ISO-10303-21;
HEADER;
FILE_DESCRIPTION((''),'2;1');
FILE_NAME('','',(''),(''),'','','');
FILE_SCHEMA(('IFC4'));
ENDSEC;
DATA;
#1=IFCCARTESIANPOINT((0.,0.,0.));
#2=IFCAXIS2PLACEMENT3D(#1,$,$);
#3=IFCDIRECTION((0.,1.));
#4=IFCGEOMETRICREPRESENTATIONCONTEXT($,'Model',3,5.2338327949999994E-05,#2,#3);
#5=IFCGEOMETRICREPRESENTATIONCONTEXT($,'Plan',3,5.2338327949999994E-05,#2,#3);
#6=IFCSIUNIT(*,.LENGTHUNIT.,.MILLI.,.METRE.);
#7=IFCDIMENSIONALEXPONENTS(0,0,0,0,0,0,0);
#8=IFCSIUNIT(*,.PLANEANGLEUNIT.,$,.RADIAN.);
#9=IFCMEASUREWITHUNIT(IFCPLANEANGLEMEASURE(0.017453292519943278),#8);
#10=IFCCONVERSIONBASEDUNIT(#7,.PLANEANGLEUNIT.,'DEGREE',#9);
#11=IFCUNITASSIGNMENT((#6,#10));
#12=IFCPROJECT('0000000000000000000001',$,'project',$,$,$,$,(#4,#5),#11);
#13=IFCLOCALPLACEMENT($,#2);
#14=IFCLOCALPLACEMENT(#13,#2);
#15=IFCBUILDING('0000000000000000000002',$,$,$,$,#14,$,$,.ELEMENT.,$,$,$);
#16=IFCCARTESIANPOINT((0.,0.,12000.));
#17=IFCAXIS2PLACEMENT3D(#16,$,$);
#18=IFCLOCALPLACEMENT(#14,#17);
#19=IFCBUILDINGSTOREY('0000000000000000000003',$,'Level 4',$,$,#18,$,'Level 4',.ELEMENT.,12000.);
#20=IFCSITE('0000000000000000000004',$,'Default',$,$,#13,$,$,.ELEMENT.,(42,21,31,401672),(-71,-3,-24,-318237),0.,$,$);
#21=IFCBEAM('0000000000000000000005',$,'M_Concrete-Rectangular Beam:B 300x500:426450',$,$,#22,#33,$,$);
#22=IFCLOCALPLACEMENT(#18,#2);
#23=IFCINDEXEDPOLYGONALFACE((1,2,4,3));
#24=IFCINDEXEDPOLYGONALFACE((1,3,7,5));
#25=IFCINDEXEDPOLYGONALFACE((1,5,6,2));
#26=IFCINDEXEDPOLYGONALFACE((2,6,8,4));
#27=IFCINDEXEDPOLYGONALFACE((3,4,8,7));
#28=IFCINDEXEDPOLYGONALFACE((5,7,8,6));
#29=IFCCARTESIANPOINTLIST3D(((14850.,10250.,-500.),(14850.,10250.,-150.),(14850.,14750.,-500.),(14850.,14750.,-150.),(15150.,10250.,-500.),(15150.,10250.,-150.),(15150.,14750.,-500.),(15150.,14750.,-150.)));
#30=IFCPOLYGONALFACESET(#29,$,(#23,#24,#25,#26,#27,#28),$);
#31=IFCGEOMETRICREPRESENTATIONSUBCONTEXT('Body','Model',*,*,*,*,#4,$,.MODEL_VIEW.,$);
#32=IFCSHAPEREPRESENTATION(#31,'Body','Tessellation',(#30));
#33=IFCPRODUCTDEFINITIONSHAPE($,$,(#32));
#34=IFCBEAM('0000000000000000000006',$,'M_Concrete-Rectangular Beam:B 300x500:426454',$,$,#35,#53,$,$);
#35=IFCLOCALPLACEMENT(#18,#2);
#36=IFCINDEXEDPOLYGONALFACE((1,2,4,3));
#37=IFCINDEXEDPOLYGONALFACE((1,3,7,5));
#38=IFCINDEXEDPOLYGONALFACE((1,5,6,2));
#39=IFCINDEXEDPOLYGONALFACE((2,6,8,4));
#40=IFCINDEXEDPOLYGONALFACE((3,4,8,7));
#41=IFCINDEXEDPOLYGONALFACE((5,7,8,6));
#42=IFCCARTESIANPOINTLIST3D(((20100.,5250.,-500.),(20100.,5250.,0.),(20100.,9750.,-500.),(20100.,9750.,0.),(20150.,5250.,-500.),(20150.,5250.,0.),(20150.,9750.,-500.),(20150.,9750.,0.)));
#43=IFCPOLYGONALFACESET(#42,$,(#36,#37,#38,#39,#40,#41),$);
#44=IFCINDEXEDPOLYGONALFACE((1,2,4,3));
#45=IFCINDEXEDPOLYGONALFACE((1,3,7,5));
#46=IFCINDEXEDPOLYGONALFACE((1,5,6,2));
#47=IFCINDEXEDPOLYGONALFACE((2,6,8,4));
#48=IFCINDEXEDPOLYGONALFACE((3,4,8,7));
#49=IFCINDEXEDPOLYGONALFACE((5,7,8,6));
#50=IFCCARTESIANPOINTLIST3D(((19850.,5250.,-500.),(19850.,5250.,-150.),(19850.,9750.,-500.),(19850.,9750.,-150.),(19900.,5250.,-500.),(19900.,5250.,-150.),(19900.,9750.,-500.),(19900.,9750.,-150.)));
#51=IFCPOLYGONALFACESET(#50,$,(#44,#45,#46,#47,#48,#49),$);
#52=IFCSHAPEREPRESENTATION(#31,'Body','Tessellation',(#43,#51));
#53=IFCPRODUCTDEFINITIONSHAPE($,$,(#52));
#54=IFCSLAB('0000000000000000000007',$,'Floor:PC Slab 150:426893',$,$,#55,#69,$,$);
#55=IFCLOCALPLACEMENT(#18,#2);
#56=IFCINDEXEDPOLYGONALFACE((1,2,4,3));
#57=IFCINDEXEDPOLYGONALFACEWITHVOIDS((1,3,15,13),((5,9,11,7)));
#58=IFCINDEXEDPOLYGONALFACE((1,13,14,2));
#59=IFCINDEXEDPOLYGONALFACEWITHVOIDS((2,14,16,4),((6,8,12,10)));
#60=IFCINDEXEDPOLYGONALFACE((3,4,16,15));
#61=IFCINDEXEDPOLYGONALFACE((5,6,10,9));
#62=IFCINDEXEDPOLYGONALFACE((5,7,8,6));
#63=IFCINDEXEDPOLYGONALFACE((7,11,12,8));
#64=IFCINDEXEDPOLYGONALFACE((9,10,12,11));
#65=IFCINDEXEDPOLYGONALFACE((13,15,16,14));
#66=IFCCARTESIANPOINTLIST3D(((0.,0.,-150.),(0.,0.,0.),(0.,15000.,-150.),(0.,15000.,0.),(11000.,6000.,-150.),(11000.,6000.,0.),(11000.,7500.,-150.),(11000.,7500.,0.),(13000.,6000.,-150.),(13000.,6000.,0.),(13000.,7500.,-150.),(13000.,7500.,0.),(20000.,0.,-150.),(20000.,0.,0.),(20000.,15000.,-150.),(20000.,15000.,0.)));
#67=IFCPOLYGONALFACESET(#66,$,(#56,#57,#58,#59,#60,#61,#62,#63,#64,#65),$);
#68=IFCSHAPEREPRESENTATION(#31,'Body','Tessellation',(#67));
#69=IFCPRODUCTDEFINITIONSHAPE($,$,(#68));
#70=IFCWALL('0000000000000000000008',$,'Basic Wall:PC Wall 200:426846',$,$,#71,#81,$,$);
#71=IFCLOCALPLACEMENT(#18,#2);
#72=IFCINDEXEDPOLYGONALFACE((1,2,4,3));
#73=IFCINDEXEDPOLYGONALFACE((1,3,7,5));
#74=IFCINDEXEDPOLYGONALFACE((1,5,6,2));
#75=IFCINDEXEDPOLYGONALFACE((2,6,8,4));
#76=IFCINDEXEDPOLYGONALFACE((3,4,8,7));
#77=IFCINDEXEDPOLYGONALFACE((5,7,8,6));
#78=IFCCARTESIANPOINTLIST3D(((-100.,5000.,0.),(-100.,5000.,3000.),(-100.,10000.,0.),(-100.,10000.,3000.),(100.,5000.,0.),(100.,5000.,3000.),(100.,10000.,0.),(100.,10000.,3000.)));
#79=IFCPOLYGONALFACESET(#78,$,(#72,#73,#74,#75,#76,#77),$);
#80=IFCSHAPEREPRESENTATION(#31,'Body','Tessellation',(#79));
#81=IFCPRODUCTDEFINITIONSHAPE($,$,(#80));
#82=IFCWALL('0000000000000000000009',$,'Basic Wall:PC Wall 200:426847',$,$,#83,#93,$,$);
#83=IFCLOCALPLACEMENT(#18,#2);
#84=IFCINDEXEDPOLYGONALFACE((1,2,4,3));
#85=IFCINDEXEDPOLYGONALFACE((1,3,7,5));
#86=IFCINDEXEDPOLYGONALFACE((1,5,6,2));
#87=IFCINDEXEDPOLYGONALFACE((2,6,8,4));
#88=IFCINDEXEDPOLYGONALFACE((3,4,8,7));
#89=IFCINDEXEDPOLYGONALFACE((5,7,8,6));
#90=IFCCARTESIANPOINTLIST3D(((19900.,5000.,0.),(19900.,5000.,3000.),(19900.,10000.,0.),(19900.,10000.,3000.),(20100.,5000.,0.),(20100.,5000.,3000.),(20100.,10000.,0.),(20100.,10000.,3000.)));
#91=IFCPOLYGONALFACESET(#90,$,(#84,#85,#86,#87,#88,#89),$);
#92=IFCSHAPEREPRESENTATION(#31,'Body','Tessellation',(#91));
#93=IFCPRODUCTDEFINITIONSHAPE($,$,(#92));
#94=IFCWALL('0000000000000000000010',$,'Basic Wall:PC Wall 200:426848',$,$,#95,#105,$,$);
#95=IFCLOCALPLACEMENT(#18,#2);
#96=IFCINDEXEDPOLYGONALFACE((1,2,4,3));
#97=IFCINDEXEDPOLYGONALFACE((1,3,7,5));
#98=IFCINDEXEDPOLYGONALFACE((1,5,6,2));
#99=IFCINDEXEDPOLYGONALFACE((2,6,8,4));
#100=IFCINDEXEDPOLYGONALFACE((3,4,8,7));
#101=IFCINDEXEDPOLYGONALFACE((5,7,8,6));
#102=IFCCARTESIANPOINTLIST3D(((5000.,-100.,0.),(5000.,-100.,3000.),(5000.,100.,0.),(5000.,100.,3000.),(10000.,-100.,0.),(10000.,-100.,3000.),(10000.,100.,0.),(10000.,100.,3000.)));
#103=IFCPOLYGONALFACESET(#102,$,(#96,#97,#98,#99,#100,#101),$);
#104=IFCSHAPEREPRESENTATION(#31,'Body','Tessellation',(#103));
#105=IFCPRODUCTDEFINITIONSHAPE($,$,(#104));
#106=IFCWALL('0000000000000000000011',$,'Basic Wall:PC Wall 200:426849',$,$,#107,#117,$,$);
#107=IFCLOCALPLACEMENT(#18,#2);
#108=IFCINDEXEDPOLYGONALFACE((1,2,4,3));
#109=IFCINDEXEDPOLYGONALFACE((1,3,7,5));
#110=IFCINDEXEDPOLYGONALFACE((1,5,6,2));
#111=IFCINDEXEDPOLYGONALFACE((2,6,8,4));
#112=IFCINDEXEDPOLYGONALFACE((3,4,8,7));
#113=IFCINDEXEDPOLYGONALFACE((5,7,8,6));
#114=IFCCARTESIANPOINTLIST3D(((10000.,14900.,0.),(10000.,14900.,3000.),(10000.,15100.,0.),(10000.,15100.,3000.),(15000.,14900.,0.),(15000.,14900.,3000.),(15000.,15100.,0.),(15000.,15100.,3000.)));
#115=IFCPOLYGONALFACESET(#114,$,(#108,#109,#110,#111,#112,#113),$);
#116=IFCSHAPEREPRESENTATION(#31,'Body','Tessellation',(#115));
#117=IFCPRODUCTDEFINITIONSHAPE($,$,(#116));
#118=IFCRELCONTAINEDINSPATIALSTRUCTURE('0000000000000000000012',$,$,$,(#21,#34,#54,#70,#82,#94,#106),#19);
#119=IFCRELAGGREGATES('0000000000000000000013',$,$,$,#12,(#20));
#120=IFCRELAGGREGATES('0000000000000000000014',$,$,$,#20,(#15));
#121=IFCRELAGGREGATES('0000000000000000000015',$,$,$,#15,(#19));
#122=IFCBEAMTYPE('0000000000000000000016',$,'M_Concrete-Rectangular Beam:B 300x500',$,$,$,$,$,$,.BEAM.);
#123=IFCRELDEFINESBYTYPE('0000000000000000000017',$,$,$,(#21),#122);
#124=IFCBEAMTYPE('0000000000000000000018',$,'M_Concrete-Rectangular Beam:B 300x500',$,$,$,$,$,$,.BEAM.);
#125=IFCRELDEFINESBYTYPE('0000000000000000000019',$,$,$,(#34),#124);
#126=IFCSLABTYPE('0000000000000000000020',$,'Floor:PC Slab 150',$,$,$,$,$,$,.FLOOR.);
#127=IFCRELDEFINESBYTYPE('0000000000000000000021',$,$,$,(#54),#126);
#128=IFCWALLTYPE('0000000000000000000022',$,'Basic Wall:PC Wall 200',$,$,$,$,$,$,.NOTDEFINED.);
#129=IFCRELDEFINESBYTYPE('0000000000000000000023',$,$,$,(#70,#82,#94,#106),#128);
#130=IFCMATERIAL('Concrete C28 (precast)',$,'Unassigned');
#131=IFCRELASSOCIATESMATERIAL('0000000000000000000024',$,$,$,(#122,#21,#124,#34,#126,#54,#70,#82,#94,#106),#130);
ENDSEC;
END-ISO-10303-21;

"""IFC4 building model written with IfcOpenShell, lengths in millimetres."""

from ifc_helpers import new_model, entity, si_unit, converted_unit, direction, frame, origin, place, context, subcontext, project, spatial, indexed_curve, outline, extrude, source, transform, mapped, material, type_object, type_shapes, element, save


model = new_model("IFC4")

# Units and contexts
model_context = context("Model", 3, precision=5.2338327949999994e-05, world=origin(), true_north=direction((0.0, 1.0)))
plan_context = context("Plan", 3, precision=5.2338327949999994e-05, world=origin(), true_north=direction((0.0, 1.0)))
body_context = subcontext(model_context, "Body", "Model", "MODEL_VIEW")
ifc_project = project(units=[si_unit("LENGTHUNIT", "METRE", prefix="MILLI"), converted_unit("PLANEANGLEUNIT", "DEGREE", entity("IfcPlaneAngleMeasure", 0.017453292519943278), si_unit("PLANEANGLEUNIT", "RADIAN"), dimensions=[0, 0, 0, 0, 0, 0, 0])], contexts=[model_context, plan_context])

# Site, building, storey
site_placement = place(None, origin())
site = spatial("IfcSite", under=ifc_project, at=site_placement, Name="Default", CompositionType="ELEMENT", RefLatitude=(42, 21, 31, 401672), RefLongitude=(-71, -3, -24, -318237), RefElevation=0.0)
building_placement = place(site_placement, origin())
building = spatial("IfcBuilding", under=site, at=building_placement, CompositionType="ELEMENT")
storey_placement = place(building_placement, frame((0.0, 0.0, 12000.0)))
storey = spatial("IfcBuildingStorey", under=building, at=storey_placement, Name="Level 4", LongName="Level 4", CompositionType="ELEMENT", Elevation=12000.0)

# Beams
ifc_material = material(Name="Concrete C28 (precast)", Category="Unassigned")
beam_type_1 = type_object("IfcBeamType", Name="M_Concrete-Rectangular Beam:B 300x500", PredefinedType="BEAM", material=ifc_material)
shared_shape_1 = source(origin(), body_context, "Body", "SweptSolid", [
    extrude(outline(indexed_curve([(-150.0, -175.0), (150.0, -175.0), (150.0, 175.0), (-150.0, 175.0), (-150.0, -175.0)], self_intersect=False)), frame((15000.0, 10250.0, 11675.0), z_axis=(0.0, 1.0, 0.0), x_axis=(-1.0, 0.0, 0.0)), (0.0, 0.0, 1.0), 4500.0),
])
type_shapes(beam_type_1, [shared_shape_1])
beam_1_placement = place(storey_placement, frame((0.0, 0.0, -12000.0)))
element("IfcBeam", 1, at=beam_1_placement, inside=storey, type_object=beam_type_1, material=ifc_material, Name="M_Concrete-Rectangular Beam:B 300x500:426450", context=body_context, shape_type="MappedRepresentation", body=[
    mapped(shared_shape_1, transform((0.0, 0.0, 0.0), scale=1.0)),
])
beam_type_2 = type_object("IfcBeamType", Name="M_Concrete-Rectangular Beam:B 300x500", PredefinedType="BEAM", material=ifc_material)
shared_shape_2 = source(origin(), body_context, "Body", "SweptSolid", [
    extrude(outline(indexed_curve([(-25.0, -250.0), (25.0, -250.0), (25.0, 250.0), (-25.0, 250.0), (-25.0, -250.0)], self_intersect=False)), frame((20125.0, 5250.0, 11750.0), z_axis=(0.0, 1.0, 0.0), x_axis=(-1.0, 0.0, 0.0)), (0.0, 0.0, 1.0), 4500.0),
    extrude(outline(indexed_curve([(-25.0, -175.0), (25.0, -175.0), (25.0, 175.0), (-25.0, 175.0), (-25.0, -175.0)], self_intersect=False)), frame((19875.0, 5250.0, 11675.0), z_axis=(0.0, 1.0, 0.0), x_axis=(-1.0, 0.0, 0.0)), (0.0, 0.0, 1.0), 4500.0),
])
type_shapes(beam_type_2, [shared_shape_2])
beam_2_placement = place(storey_placement, frame((0.0, 0.0, -12000.0)))
element("IfcBeam", 2, at=beam_2_placement, inside=storey, type_object=beam_type_2, material=ifc_material, Name="M_Concrete-Rectangular Beam:B 300x500:426454", context=body_context, shape_type="MappedRepresentation", body=[
    mapped(shared_shape_2, transform((0.0, 0.0, 0.0), scale=1.0)),
])

# Slab, opening
slab_type = type_object("IfcSlabType", Name="Floor:PC Slab 150", PredefinedType="FLOOR", material=ifc_material)
slab_placement = place(storey_placement, origin())
slab = element("IfcSlab", 3, at=slab_placement, inside=storey, type_object=slab_type, material=ifc_material, Name="Floor:PC Slab 150:426893", context=body_context, shape_type="SweptSolid", body=[
    extrude(outline(indexed_curve([(-7500.0, -10000.0), (7500.0, -10000.0), (7500.0, 10000.0), (-7500.0, 10000.0), (-7500.0, -10000.0)], self_intersect=False), holes=[indexed_curve([(-1500.0, -3000.0), (-1500.0, -1000.0), (0.0, -1000.0), (0.0, -3000.0), (-1500.0, -3000.0)], self_intersect=False)]), frame((10000.0, 7500.0, -150.0), z_axis=(0.0, 0.0, 1.0), x_axis=(0.0, 1.0, 0.0)), (0.0, 0.0, 1.0), 150.0),
])
opening_placement = place(slab_placement, origin())
element("IfcOpeningElement", 4, at=opening_placement, cuts=slab, PredefinedType="OPENING", context=body_context, shape_type="SweptSolid", body=[
    extrude(outline(indexed_curve([(13000.0, 6000.0), (13000.0, 7500.0), (11000.0, 7500.0), (11000.0, 6000.0), (13000.0, 6000.0)], self_intersect=False)), frame((0.0, 0.0, -12000.0)), (0.0, 0.0, 1.0), 20000.0),
])

# Walls
wall_type = type_object("IfcWallType", Name="Basic Wall:PC Wall 200", PredefinedType="NOTDEFINED")
wall_1_placement = place(storey_placement, frame((0.0, 5000.0, 0.0), z_axis=(0.0, 0.0, 1.0), x_axis=(0.0, 1.0, 0.0)))
element("IfcWall", 5, at=wall_1_placement, inside=storey, type_object=wall_type, material=ifc_material, Name="Basic Wall:PC Wall 200:426846", context=body_context, shape_type="SweptSolid", body=[
    extrude(outline(indexed_curve([(5000.0, 100.0), (0.0, 100.0), (0.0, -100.0), (5000.0, -100.0), (5000.0, 100.0)], self_intersect=False)), origin(), (0.0, 0.0, 1.0), 3000.0),
])
wall_2_placement = place(storey_placement, frame((20000.0, 5000.0, 0.0), z_axis=(0.0, 0.0, 1.0), x_axis=(0.0, 1.0, 0.0)))
element("IfcWall", 6, at=wall_2_placement, inside=storey, type_object=wall_type, material=ifc_material, Name="Basic Wall:PC Wall 200:426847", context=body_context, shape_type="SweptSolid", body=[
    extrude(outline(indexed_curve([(5000.0, 100.0), (0.0, 100.0), (0.0, -100.0), (5000.0, -100.0), (5000.0, 100.0)], self_intersect=False)), origin(), (0.0, 0.0, 1.0), 3000.0),
])
wall_3_placement = place(storey_placement, frame((5000.0, 0.0, 0.0)))
element("IfcWall", 7, at=wall_3_placement, inside=storey, type_object=wall_type, material=ifc_material, Name="Basic Wall:PC Wall 200:426848", context=body_context, shape_type="SweptSolid", body=[
    extrude(outline(indexed_curve([(5000.0, 100.0), (0.0, 100.0), (0.0, -100.0), (5000.0, -100.0), (5000.0, 100.0)], self_intersect=False)), origin(), (0.0, 0.0, 1.0), 3000.0),
])
wall_4_placement = place(storey_placement, frame((10000.0, 15000.0, 0.0)))
element("IfcWall", 8, at=wall_4_placement, inside=storey, type_object=wall_type, material=ifc_material, Name="Basic Wall:PC Wall 200:426849", context=body_context, shape_type="SweptSolid", body=[
    extrude(outline(indexed_curve([(5000.0, 100.0), (0.0, 100.0), (0.0, -100.0), (5000.0, -100.0), (5000.0, 100.0)], self_intersect=False)), origin(), (0.0, 0.0, 1.0), 3000.0),
])

save(model, "model.ifc")
